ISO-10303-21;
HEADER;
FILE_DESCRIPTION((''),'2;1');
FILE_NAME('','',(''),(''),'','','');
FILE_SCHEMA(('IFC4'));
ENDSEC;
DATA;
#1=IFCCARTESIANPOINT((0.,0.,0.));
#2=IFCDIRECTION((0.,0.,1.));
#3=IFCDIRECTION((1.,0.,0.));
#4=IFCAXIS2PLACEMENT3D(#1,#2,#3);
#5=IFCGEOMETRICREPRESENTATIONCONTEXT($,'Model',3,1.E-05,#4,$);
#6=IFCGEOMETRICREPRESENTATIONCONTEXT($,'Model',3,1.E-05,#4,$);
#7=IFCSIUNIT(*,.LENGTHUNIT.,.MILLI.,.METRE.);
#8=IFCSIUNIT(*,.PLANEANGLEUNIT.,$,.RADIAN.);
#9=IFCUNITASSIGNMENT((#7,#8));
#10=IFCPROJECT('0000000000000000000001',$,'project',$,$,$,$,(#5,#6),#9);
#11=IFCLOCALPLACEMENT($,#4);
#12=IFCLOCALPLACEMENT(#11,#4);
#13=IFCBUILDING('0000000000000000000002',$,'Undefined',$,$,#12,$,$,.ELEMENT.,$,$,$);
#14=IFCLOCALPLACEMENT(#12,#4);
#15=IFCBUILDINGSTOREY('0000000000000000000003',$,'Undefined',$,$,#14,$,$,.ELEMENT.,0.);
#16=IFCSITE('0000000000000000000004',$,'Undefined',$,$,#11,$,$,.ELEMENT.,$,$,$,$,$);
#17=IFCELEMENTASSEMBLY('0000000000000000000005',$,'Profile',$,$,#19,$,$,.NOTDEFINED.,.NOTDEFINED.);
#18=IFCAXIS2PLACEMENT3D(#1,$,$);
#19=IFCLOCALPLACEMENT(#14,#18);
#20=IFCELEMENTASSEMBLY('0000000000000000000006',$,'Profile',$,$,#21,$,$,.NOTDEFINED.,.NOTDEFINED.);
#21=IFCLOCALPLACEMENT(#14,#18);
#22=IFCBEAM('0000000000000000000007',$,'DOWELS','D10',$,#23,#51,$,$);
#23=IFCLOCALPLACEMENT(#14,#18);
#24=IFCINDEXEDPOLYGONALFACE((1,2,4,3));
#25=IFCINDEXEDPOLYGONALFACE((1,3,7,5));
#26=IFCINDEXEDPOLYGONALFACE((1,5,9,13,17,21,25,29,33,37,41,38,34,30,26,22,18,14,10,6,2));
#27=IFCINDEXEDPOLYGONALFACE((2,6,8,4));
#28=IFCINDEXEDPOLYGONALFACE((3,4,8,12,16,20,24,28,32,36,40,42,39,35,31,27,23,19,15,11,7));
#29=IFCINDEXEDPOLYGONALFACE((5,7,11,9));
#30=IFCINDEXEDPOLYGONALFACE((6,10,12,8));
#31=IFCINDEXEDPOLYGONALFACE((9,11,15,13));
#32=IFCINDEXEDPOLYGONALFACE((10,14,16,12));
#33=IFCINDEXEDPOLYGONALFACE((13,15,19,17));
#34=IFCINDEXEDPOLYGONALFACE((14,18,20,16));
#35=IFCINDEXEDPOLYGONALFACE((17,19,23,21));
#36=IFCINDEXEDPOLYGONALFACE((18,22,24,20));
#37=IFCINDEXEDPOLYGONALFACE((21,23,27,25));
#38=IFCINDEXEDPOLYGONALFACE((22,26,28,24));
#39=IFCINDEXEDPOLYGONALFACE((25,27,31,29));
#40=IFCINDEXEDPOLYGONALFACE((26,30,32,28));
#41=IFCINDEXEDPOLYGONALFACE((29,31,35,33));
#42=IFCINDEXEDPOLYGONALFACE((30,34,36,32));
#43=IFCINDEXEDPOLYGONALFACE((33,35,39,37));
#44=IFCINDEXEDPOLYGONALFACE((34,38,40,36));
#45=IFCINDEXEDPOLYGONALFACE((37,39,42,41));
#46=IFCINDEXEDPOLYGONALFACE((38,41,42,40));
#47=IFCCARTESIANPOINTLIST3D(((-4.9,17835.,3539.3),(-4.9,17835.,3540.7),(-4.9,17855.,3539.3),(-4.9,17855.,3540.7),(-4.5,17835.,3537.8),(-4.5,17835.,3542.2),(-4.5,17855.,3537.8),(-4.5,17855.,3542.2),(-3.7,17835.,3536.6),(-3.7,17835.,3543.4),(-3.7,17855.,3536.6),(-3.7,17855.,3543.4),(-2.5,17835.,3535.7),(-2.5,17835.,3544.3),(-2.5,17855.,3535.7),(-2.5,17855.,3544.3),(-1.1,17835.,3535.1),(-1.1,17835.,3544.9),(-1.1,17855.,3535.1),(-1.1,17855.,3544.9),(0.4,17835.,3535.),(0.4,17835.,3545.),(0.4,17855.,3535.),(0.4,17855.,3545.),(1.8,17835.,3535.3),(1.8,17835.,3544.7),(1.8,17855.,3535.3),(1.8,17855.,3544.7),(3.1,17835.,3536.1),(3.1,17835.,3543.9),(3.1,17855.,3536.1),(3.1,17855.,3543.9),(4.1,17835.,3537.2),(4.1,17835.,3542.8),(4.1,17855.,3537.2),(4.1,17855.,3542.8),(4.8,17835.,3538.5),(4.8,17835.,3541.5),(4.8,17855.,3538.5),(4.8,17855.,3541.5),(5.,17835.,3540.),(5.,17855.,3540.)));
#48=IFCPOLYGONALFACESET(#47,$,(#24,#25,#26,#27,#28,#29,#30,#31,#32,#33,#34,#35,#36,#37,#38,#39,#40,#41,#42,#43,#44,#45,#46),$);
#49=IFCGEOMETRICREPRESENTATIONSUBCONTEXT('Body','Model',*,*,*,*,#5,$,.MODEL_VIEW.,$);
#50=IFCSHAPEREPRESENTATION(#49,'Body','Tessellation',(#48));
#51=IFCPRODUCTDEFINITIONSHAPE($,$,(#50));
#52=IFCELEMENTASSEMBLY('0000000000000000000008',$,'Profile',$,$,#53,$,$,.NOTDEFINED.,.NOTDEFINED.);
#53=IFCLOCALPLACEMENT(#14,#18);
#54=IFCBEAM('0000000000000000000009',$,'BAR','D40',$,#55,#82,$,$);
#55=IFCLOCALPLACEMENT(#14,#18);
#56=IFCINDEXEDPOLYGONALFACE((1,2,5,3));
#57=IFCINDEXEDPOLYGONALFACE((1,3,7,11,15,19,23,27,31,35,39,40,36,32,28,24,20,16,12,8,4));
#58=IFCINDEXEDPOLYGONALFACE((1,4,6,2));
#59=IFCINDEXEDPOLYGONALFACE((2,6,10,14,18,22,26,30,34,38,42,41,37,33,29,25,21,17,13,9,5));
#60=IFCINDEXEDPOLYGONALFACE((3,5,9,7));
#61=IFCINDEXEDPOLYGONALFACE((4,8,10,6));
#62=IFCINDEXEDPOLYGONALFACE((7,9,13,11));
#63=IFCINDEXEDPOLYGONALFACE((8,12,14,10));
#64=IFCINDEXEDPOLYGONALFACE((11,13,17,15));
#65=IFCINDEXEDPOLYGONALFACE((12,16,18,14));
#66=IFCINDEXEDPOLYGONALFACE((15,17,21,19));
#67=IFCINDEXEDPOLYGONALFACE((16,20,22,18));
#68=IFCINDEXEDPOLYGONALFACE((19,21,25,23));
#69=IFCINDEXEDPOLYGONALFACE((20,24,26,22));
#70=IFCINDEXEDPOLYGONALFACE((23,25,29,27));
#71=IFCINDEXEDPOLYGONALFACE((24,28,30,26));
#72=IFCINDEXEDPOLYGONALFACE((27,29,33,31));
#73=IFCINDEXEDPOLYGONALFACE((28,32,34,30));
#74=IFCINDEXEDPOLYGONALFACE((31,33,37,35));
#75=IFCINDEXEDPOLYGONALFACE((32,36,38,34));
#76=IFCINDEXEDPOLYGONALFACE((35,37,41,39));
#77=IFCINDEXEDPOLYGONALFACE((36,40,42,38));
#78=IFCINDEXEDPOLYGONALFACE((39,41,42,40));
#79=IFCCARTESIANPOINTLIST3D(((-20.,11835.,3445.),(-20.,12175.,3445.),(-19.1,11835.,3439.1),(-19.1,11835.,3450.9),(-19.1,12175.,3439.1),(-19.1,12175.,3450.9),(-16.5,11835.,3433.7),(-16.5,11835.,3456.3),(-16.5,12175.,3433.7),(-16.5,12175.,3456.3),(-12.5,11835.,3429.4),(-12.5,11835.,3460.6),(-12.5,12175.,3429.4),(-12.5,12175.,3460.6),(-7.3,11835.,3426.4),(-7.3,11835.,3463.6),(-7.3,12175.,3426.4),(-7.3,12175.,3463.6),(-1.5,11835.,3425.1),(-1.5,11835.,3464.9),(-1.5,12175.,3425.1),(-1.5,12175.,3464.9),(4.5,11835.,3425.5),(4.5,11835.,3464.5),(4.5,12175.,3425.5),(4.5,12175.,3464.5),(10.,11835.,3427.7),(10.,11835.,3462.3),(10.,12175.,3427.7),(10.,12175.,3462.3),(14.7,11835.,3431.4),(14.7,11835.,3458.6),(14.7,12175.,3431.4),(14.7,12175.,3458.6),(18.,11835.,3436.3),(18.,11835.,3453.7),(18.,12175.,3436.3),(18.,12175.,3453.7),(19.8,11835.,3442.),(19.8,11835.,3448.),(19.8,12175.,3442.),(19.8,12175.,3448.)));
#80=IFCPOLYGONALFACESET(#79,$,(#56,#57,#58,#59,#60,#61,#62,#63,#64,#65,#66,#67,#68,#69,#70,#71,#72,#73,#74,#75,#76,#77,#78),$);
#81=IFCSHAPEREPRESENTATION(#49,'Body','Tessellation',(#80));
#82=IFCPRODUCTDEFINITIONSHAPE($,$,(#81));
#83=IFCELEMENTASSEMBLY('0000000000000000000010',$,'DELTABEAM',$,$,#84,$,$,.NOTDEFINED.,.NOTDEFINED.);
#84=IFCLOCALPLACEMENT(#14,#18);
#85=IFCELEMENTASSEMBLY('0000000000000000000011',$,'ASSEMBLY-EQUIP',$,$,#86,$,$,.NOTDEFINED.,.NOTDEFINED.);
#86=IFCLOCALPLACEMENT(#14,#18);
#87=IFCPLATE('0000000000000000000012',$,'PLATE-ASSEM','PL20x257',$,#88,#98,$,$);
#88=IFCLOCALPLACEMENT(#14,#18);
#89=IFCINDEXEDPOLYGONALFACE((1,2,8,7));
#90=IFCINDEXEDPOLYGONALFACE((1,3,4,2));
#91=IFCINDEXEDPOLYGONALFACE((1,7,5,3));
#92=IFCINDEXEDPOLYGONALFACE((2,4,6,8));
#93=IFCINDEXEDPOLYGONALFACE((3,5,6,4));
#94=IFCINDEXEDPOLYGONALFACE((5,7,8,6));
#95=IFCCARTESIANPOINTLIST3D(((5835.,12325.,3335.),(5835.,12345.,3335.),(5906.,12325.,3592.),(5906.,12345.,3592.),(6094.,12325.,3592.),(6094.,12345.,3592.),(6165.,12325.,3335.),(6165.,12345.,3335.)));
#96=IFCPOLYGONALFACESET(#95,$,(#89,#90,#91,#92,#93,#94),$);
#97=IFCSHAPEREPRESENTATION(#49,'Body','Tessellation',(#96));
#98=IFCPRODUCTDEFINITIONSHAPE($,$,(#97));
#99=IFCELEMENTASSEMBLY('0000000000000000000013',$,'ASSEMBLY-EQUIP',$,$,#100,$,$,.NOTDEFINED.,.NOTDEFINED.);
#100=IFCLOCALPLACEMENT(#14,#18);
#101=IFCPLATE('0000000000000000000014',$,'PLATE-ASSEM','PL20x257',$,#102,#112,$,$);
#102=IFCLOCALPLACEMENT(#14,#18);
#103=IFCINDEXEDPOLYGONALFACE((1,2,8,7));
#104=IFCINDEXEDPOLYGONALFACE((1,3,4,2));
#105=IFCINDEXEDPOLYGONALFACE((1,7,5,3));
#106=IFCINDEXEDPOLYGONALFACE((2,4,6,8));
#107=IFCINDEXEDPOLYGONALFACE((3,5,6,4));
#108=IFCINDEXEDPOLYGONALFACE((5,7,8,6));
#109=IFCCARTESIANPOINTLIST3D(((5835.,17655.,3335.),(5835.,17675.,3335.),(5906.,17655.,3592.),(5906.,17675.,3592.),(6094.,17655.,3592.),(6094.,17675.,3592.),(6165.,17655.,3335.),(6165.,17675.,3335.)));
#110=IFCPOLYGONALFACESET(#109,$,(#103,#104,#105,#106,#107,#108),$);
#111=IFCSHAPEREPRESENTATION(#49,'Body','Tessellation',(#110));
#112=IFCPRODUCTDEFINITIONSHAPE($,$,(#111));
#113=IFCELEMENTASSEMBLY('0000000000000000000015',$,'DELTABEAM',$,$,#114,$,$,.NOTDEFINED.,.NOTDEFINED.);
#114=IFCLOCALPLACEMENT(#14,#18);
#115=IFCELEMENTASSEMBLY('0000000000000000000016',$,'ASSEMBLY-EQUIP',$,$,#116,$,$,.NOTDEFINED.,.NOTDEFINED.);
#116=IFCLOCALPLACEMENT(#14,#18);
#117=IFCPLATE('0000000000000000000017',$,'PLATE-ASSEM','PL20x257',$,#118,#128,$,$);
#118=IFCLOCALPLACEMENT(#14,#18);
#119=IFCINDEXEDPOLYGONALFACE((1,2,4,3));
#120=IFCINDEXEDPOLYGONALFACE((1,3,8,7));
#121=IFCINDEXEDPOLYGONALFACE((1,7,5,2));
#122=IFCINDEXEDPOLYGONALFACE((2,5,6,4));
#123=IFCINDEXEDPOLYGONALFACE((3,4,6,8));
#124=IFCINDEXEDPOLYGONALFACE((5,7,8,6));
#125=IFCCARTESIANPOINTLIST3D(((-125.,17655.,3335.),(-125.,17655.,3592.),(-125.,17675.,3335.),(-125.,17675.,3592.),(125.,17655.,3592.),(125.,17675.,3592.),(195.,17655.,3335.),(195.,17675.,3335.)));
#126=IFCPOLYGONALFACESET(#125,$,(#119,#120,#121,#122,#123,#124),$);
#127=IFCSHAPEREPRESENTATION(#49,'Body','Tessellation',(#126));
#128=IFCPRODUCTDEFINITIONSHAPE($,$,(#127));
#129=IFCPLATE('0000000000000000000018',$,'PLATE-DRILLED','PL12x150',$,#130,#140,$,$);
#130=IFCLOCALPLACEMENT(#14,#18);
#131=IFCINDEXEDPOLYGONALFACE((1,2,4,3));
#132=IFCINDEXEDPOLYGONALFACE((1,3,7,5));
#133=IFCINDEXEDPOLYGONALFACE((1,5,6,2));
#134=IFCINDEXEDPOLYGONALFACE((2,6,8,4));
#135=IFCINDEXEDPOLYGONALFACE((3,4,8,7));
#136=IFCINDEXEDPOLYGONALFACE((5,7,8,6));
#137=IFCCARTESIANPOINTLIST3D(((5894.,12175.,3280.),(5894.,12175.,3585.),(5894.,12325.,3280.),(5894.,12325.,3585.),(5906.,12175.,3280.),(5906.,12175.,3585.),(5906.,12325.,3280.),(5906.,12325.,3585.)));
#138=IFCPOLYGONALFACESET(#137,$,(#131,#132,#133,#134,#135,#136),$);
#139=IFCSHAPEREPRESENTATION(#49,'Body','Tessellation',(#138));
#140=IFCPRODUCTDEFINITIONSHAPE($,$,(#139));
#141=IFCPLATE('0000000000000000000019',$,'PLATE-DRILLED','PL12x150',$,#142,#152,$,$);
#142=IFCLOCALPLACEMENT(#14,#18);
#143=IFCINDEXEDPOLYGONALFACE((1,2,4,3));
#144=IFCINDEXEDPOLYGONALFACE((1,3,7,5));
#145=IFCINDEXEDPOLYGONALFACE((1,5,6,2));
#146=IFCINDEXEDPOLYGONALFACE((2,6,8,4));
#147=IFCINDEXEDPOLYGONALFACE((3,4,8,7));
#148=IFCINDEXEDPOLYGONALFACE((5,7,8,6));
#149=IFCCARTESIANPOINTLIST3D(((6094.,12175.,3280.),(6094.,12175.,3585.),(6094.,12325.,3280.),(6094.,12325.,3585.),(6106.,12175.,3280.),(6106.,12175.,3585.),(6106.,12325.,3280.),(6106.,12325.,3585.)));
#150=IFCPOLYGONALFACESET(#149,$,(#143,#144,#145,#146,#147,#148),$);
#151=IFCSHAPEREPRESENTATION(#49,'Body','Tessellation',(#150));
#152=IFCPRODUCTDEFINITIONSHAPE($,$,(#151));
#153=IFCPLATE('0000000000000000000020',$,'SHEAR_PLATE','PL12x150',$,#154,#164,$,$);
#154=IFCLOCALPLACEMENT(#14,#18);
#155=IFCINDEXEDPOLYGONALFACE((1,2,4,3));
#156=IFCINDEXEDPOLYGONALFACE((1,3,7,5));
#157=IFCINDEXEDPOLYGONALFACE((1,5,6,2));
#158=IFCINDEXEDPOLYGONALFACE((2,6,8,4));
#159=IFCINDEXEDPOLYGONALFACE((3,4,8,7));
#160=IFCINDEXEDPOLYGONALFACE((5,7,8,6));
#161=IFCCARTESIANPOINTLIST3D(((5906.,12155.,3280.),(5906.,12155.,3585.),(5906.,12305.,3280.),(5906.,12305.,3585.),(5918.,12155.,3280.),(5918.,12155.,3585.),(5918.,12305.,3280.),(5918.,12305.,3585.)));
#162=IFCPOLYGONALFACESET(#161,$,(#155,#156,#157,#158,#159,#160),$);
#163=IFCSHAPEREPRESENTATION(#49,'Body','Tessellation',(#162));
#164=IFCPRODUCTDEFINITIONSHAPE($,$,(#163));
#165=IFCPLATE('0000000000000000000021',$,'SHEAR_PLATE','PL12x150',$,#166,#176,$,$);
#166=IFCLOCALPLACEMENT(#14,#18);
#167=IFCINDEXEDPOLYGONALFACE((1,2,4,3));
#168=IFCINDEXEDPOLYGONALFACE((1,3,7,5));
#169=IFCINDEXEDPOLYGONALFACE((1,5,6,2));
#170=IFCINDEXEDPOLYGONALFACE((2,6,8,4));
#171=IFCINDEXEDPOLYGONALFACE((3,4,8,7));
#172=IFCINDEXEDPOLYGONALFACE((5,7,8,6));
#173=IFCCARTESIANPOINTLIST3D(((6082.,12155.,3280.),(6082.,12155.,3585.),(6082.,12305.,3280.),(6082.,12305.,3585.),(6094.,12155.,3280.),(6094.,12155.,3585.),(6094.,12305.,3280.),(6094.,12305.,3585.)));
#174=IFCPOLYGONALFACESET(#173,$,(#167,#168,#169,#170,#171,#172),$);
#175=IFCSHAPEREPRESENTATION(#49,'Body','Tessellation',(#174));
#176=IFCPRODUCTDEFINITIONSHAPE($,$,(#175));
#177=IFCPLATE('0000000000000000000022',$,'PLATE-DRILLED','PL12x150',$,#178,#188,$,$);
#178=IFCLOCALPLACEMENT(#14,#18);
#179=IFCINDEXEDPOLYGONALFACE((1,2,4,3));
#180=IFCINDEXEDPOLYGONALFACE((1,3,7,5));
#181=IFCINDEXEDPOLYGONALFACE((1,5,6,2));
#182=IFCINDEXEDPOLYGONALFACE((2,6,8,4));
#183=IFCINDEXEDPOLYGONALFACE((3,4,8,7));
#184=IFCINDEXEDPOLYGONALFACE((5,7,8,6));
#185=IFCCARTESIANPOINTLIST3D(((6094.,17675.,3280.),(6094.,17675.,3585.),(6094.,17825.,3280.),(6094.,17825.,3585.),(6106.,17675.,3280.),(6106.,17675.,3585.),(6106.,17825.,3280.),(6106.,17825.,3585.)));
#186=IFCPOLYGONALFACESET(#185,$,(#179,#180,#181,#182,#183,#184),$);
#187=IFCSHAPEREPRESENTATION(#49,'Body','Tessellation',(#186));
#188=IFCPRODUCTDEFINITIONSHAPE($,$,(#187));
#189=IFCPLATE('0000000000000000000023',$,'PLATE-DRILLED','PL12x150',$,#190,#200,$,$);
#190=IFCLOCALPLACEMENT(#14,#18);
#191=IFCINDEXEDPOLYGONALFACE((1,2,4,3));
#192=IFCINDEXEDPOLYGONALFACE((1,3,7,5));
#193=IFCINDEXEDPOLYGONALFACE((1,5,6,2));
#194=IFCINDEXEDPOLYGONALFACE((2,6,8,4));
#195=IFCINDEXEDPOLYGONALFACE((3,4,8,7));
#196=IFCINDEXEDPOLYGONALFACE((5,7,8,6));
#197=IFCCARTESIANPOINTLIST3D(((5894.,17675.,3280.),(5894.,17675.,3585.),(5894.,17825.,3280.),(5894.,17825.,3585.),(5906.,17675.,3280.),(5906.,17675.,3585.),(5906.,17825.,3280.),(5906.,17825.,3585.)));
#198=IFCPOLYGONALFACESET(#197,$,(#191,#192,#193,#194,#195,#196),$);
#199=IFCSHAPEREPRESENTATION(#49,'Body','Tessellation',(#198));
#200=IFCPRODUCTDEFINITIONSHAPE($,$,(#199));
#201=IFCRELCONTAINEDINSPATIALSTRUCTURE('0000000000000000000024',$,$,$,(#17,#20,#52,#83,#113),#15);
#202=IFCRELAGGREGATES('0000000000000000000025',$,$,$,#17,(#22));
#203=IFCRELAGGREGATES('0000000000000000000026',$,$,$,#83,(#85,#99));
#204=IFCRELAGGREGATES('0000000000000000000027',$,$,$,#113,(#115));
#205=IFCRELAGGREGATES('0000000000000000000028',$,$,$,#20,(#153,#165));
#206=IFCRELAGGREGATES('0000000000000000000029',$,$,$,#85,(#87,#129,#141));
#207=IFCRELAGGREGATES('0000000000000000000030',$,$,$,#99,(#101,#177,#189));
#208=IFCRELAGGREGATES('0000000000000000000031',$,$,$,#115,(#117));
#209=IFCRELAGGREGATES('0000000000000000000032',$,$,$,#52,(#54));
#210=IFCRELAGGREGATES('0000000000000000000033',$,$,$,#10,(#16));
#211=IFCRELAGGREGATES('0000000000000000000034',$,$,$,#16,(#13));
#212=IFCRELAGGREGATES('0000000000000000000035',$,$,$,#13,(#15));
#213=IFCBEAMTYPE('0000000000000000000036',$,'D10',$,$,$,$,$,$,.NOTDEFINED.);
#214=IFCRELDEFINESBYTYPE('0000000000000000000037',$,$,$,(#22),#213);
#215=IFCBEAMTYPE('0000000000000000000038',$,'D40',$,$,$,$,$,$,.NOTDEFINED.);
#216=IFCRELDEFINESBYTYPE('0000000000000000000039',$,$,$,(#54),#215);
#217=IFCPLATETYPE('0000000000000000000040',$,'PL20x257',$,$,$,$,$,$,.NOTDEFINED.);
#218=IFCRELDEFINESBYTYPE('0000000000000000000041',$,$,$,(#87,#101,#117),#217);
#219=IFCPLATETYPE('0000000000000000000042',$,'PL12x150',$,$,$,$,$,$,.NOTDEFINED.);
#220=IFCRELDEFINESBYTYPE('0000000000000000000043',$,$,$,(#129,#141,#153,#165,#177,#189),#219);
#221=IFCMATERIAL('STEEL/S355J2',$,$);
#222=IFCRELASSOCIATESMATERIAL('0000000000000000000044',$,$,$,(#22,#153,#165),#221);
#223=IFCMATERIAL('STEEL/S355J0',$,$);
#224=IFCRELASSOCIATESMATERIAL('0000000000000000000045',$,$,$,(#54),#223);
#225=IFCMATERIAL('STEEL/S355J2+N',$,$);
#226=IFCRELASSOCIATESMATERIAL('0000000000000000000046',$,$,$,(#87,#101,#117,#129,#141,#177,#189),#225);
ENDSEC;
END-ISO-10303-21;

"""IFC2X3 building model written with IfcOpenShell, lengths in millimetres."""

from ifc_helpers import new_model, si_unit, frame, origin_with_axes, origin_2d_with_axis, place, context, subcontext, project, spatial, polyline, circle, outline, extrude, material, type_object, element, aggregate, save


model = new_model("IFC2X3")

# Units and contexts
model_context_1 = context("Model", 3, precision=1e-05, world=origin_with_axes())
model_context_2 = context("Model", 3, precision=1e-05, world=origin_with_axes())
body_context = subcontext(model_context_1, "Body", "Model", "MODEL_VIEW")
ifc_project = project(units=[si_unit("LENGTHUNIT", "METRE", prefix="MILLI"), si_unit("PLANEANGLEUNIT", "RADIAN")], contexts=[model_context_1, model_context_2])

# Site, building, storey
site_placement = place(None, origin_with_axes())
site = spatial("IfcSite", under=ifc_project, at=site_placement, Name="Undefined", CompositionType="ELEMENT")
building_placement = place(site_placement, origin_with_axes())
building = spatial("IfcBuilding", under=site, at=building_placement, Name="Undefined", CompositionType="ELEMENT")
storey_placement = place(building_placement, origin_with_axes())
storey = spatial("IfcBuildingStorey", under=building, at=storey_placement, Name="Undefined", CompositionType="ELEMENT", Elevation=0.0)

# Element assembly
assembly_1_placement = place(storey_placement, origin_with_axes())
assembly_1 = element("IfcElementAssembly", 1, at=assembly_1_placement, inside=storey, Name="Profile", AssemblyPlace="NOTDEFINED", PredefinedType="NOTDEFINED")

# Element assembly
assembly_2_placement = place(storey_placement, origin_with_axes())
assembly_2 = element("IfcElementAssembly", 2, at=assembly_2_placement, inside=storey, Name="Profile", AssemblyPlace="NOTDEFINED", PredefinedType="NOTDEFINED")
ifc_material_1 = material(Name="STEEL/S355J2")
beam_type_1 = type_object("IfcBeamType", Name="D10", PredefinedType="NOTDEFINED")

# Beam
beam_1_placement = place(assembly_1_placement, frame((0.0, 17835.0, 3540.0), z_axis=(0.0, 0.0, 1.0), x_axis=(0.0, 1.0, 0.0)))
beam_1 = element("IfcBeam", 3, at=beam_1_placement, type_object=beam_type_1, material=ifc_material_1, Name="DOWELS", Description="D10", context=body_context, shape_type="SweptSolid", body=[
    extrude(circle(Radius=5.0, at=origin_2d_with_axis()), frame((20.0, 0.0, 0.0), z_axis=(-1.0, 0.0, 0.0), x_axis=(0.0, -1.0, 0.0)), (0.0, 0.0, 1.0), 20.0),
])
aggregate(assembly_1, [beam_1])

# Element assembly, beam
assembly_3_placement = place(storey_placement, origin_with_axes())
assembly_3 = element("IfcElementAssembly", 4, at=assembly_3_placement, inside=storey, Name="Profile", AssemblyPlace="NOTDEFINED", PredefinedType="NOTDEFINED")
ifc_material_2 = material(Name="STEEL/S355J0")
beam_type_2 = type_object("IfcBeamType", Name="D40", PredefinedType="NOTDEFINED")
beam_2_placement = place(assembly_3_placement, frame((0.0, 12175.0, 3445.0), z_axis=(0.0, 0.0, 1.0), x_axis=(0.0, -1.0, 0.0)))
beam_2 = element("IfcBeam", 5, at=beam_2_placement, type_object=beam_type_2, material=ifc_material_2, Name="BAR", Description="D40", context=body_context, shape_type="SweptSolid", body=[
    extrude(circle(Radius=20.0, at=origin_2d_with_axis()), frame((340.0, 0.0, 0.0), z_axis=(-1.0, 0.0, 0.0), x_axis=(0.0, -1.0, 0.0)), (0.0, 0.0, 1.0), 340.0),
])

# Element assemblies, plates
assembly_4_placement = place(storey_placement, origin_with_axes())
assembly_4 = element("IfcElementAssembly", 6, at=assembly_4_placement, inside=storey, Name="DELTABEAM", AssemblyPlace="NOTDEFINED", PredefinedType="NOTDEFINED")
assembly_5_placement = place(assembly_4_placement, origin_with_axes())
assembly_5 = element("IfcElementAssembly", 7, at=assembly_5_placement, Name="ASSEMBLY-EQUIP", AssemblyPlace="NOTDEFINED", PredefinedType="NOTDEFINED")
ifc_material_3 = material(Name="STEEL/S355J2+N")
plate_type_1 = type_object("IfcPlateType", Name="PL20x257", PredefinedType="NOTDEFINED")
plate_1_placement = place(assembly_5_placement, frame((6165.0, 12335.0, 3335.0), z_axis=(0.0, 1.0, 0.0), x_axis=(-1.0, 0.0, 0.0)))
plate_1 = element("IfcPlate", 8, at=plate_1_placement, type_object=plate_type_1, material=ifc_material_3, Name="PLATE-ASSEM", Description="PL20x257", context=body_context, shape_type="SweptSolid", body=[
    extrude(outline(polyline([(0.0, 0.0), (330.0, 0.0), (259.0, 257.0), (71.0, 257.0), (0.0, 0.0)])), frame((0.0, 0.0, -10.0), z_axis=(0.0, 0.0, 1.0), x_axis=(1.0, 0.0, 0.0)), (0.0, 0.0, 1.0), 20.0),
])
assembly_6_placement = place(assembly_4_placement, origin_with_axes())
assembly_6 = element("IfcElementAssembly", 9, at=assembly_6_placement, Name="ASSEMBLY-EQUIP", AssemblyPlace="NOTDEFINED", PredefinedType="NOTDEFINED")
aggregate(assembly_4, [assembly_5, assembly_6])
plate_2_placement = place(assembly_6_placement, frame((5835.0, 17665.0, 3335.0), z_axis=(0.0, -1.0, 0.0), x_axis=(1.0, 0.0, 0.0)))
plate_2 = element("IfcPlate", 10, at=plate_2_placement, type_object=plate_type_1, material=ifc_material_3, Name="PLATE-ASSEM", Description="PL20x257", context=body_context, shape_type="SweptSolid", body=[
    extrude(outline(polyline([(0.0, 0.0), (330.0, 0.0), (259.0, 257.0), (71.0, 257.0), (0.0, 0.0)])), frame((0.0, 0.0, -10.0), z_axis=(0.0, 0.0, 1.0), x_axis=(1.0, 0.0, 0.0)), (0.0, 0.0, 1.0), 20.0),
])
assembly_7_placement = place(storey_placement, origin_with_axes())
assembly_7 = element("IfcElementAssembly", 11, at=assembly_7_placement, inside=storey, Name="DELTABEAM", AssemblyPlace="NOTDEFINED", PredefinedType="NOTDEFINED")
assembly_8_placement = place(assembly_7_placement, origin_with_axes())
assembly_8 = element("IfcElementAssembly", 12, at=assembly_8_placement, Name="ASSEMBLY-EQUIP", AssemblyPlace="NOTDEFINED", PredefinedType="NOTDEFINED")
plate_3_placement = place(assembly_8_placement, frame((-125.0, 17665.0, 3335.0), z_axis=(0.0, -1.0, 0.0), x_axis=(1.0, 0.0, 0.0)))
plate_3 = element("IfcPlate", 13, at=plate_3_placement, type_object=plate_type_1, material=ifc_material_3, Name="PLATE-ASSEM", Description="PL20x257", context=body_context, shape_type="SweptSolid", body=[
    extrude(outline(polyline([(0.0, 0.0), (320.0, 0.0), (250.0, 257.0), (0.0, 257.0), (0.0, 0.0)])), frame((0.0, 0.0, -10.0), z_axis=(0.0, 0.0, 1.0), x_axis=(1.0, 0.0, 0.0)), (0.0, 0.0, 1.0), 20.0),
])
aggregate(assembly_7, [assembly_8])

# Plates
plate_type_2 = type_object("IfcPlateType", Name="PL12x150", PredefinedType="NOTDEFINED")
plate_4_placement = place(assembly_5_placement, frame((5900.0, 12325.0, 3585.0), z_axis=(1.0, 0.0, 0.0), x_axis=(0.0, -1.0, 0.0)))
plate_4 = element("IfcPlate", 14, at=plate_4_placement, type_object=plate_type_2, material=ifc_material_3, Name="PLATE-DRILLED", Description="PL12x150", context=body_context, shape_type="SweptSolid", body=[
    extrude(outline(polyline([(0.0, 0.0), (150.0, 0.0), (150.0, 0.0), (150.0, 305.0), (150.0, 305.0), (0.0, 305.0), (0.0, 305.0), (0.0, 0.0)])), frame((0.0, 0.0, -6.0), z_axis=(0.0, 0.0, 1.0), x_axis=(1.0, 0.0, 0.0)), (0.0, 0.0, 1.0), 12.0),
])
plate_5_placement = place(assembly_5_placement, frame((6100.0, 12325.0, 3585.0), z_axis=(1.0, 0.0, 0.0), x_axis=(0.0, -1.0, 0.0)))
plate_5 = element("IfcPlate", 15, at=plate_5_placement, type_object=plate_type_2, material=ifc_material_3, Name="PLATE-DRILLED", Description="PL12x150", context=body_context, shape_type="SweptSolid", body=[
    extrude(outline(polyline([(0.0, 0.0), (150.0, 0.0), (150.0, 0.0), (150.0, 305.0), (150.0, 305.0), (0.0, 305.0), (0.0, 305.0), (0.0, 0.0)])), frame((0.0, 0.0, -6.0), z_axis=(0.0, 0.0, 1.0), x_axis=(1.0, 0.0, 0.0)), (0.0, 0.0, 1.0), 12.0),
])
plate_6_placement = place(assembly_2_placement, frame((5912.0, 12155.0, 3585.0), z_axis=(-1.0, 0.0, 0.0), x_axis=(0.0, 1.0, 0.0)))
plate_6 = element("IfcPlate", 16, at=plate_6_placement, type_object=plate_type_2, material=ifc_material_1, Name="SHEAR_PLATE", Description="PL12x150", context=body_context, shape_type="SweptSolid", body=[
    extrude(outline(polyline([(0.0, 0.0), (150.0, 0.0), (150.0, 0.0), (150.0, 305.0), (150.0, 305.0), (0.0, 305.0), (0.0, 305.0), (0.0, 0.0)])), frame((0.0, 0.0, -6.0), z_axis=(0.0, 0.0, 1.0), x_axis=(1.0, 0.0, 0.0)), (0.0, 0.0, 1.0), 12.0),
])
plate_7_placement = place(assembly_2_placement, frame((6088.0, 12155.0, 3585.0), z_axis=(-1.0, 0.0, 0.0), x_axis=(0.0, 1.0, 0.0)))
plate_7 = element("IfcPlate", 17, at=plate_7_placement, type_object=plate_type_2, material=ifc_material_1, Name="SHEAR_PLATE", Description="PL12x150", context=body_context, shape_type="SweptSolid", body=[
    extrude(outline(polyline([(0.0, 0.0), (150.0, 0.0), (150.0, 0.0), (150.0, 305.0), (150.0, 305.0), (0.0, 305.0), (0.0, 305.0), (0.0, 0.0)])), frame((0.0, 0.0, -6.0), z_axis=(0.0, 0.0, 1.0), x_axis=(1.0, 0.0, 0.0)), (0.0, 0.0, 1.0), 12.0),
])
aggregate(assembly_2, [plate_6, plate_7])
plate_8_placement = place(assembly_6_placement, frame((6100.0, 17675.0, 3585.0), z_axis=(-1.0, 0.0, 0.0), x_axis=(0.0, 1.0, 0.0)))
plate_8 = element("IfcPlate", 18, at=plate_8_placement, type_object=plate_type_2, material=ifc_material_3, Name="PLATE-DRILLED", Description="PL12x150", context=body_context, shape_type="SweptSolid", body=[
    extrude(outline(polyline([(0.0, 0.0), (150.0, 0.0), (150.0, 0.0), (150.0, 305.0), (150.0, 305.0), (0.0, 305.0), (0.0, 305.0), (0.0, 0.0)])), frame((0.0, 0.0, -6.0), z_axis=(0.0, 0.0, 1.0), x_axis=(1.0, 0.0, 0.0)), (0.0, 0.0, 1.0), 12.0),
])
plate_9_placement = place(assembly_6_placement, frame((5900.0, 17675.0, 3585.0), z_axis=(-1.0, 0.0, 0.0), x_axis=(0.0, 1.0, 0.0)))
plate_9 = element("IfcPlate", 19, at=plate_9_placement, type_object=plate_type_2, material=ifc_material_3, Name="PLATE-DRILLED", Description="PL12x150", context=body_context, shape_type="SweptSolid", body=[
    extrude(outline(polyline([(0.0, 0.0), (150.0, 0.0), (150.0, 0.0), (150.0, 305.0), (150.0, 305.0), (0.0, 305.0), (0.0, 305.0), (0.0, 0.0)])), frame((0.0, 0.0, -6.0), z_axis=(0.0, 0.0, 1.0), x_axis=(1.0, 0.0, 0.0)), (0.0, 0.0, 1.0), 12.0),
])

aggregate(assembly_5, [plate_1, plate_4, plate_5])
aggregate(assembly_6, [plate_2, plate_8, plate_9])
aggregate(assembly_8, [plate_3])
aggregate(assembly_3, [beam_2])

save(model, "model.ifc")
